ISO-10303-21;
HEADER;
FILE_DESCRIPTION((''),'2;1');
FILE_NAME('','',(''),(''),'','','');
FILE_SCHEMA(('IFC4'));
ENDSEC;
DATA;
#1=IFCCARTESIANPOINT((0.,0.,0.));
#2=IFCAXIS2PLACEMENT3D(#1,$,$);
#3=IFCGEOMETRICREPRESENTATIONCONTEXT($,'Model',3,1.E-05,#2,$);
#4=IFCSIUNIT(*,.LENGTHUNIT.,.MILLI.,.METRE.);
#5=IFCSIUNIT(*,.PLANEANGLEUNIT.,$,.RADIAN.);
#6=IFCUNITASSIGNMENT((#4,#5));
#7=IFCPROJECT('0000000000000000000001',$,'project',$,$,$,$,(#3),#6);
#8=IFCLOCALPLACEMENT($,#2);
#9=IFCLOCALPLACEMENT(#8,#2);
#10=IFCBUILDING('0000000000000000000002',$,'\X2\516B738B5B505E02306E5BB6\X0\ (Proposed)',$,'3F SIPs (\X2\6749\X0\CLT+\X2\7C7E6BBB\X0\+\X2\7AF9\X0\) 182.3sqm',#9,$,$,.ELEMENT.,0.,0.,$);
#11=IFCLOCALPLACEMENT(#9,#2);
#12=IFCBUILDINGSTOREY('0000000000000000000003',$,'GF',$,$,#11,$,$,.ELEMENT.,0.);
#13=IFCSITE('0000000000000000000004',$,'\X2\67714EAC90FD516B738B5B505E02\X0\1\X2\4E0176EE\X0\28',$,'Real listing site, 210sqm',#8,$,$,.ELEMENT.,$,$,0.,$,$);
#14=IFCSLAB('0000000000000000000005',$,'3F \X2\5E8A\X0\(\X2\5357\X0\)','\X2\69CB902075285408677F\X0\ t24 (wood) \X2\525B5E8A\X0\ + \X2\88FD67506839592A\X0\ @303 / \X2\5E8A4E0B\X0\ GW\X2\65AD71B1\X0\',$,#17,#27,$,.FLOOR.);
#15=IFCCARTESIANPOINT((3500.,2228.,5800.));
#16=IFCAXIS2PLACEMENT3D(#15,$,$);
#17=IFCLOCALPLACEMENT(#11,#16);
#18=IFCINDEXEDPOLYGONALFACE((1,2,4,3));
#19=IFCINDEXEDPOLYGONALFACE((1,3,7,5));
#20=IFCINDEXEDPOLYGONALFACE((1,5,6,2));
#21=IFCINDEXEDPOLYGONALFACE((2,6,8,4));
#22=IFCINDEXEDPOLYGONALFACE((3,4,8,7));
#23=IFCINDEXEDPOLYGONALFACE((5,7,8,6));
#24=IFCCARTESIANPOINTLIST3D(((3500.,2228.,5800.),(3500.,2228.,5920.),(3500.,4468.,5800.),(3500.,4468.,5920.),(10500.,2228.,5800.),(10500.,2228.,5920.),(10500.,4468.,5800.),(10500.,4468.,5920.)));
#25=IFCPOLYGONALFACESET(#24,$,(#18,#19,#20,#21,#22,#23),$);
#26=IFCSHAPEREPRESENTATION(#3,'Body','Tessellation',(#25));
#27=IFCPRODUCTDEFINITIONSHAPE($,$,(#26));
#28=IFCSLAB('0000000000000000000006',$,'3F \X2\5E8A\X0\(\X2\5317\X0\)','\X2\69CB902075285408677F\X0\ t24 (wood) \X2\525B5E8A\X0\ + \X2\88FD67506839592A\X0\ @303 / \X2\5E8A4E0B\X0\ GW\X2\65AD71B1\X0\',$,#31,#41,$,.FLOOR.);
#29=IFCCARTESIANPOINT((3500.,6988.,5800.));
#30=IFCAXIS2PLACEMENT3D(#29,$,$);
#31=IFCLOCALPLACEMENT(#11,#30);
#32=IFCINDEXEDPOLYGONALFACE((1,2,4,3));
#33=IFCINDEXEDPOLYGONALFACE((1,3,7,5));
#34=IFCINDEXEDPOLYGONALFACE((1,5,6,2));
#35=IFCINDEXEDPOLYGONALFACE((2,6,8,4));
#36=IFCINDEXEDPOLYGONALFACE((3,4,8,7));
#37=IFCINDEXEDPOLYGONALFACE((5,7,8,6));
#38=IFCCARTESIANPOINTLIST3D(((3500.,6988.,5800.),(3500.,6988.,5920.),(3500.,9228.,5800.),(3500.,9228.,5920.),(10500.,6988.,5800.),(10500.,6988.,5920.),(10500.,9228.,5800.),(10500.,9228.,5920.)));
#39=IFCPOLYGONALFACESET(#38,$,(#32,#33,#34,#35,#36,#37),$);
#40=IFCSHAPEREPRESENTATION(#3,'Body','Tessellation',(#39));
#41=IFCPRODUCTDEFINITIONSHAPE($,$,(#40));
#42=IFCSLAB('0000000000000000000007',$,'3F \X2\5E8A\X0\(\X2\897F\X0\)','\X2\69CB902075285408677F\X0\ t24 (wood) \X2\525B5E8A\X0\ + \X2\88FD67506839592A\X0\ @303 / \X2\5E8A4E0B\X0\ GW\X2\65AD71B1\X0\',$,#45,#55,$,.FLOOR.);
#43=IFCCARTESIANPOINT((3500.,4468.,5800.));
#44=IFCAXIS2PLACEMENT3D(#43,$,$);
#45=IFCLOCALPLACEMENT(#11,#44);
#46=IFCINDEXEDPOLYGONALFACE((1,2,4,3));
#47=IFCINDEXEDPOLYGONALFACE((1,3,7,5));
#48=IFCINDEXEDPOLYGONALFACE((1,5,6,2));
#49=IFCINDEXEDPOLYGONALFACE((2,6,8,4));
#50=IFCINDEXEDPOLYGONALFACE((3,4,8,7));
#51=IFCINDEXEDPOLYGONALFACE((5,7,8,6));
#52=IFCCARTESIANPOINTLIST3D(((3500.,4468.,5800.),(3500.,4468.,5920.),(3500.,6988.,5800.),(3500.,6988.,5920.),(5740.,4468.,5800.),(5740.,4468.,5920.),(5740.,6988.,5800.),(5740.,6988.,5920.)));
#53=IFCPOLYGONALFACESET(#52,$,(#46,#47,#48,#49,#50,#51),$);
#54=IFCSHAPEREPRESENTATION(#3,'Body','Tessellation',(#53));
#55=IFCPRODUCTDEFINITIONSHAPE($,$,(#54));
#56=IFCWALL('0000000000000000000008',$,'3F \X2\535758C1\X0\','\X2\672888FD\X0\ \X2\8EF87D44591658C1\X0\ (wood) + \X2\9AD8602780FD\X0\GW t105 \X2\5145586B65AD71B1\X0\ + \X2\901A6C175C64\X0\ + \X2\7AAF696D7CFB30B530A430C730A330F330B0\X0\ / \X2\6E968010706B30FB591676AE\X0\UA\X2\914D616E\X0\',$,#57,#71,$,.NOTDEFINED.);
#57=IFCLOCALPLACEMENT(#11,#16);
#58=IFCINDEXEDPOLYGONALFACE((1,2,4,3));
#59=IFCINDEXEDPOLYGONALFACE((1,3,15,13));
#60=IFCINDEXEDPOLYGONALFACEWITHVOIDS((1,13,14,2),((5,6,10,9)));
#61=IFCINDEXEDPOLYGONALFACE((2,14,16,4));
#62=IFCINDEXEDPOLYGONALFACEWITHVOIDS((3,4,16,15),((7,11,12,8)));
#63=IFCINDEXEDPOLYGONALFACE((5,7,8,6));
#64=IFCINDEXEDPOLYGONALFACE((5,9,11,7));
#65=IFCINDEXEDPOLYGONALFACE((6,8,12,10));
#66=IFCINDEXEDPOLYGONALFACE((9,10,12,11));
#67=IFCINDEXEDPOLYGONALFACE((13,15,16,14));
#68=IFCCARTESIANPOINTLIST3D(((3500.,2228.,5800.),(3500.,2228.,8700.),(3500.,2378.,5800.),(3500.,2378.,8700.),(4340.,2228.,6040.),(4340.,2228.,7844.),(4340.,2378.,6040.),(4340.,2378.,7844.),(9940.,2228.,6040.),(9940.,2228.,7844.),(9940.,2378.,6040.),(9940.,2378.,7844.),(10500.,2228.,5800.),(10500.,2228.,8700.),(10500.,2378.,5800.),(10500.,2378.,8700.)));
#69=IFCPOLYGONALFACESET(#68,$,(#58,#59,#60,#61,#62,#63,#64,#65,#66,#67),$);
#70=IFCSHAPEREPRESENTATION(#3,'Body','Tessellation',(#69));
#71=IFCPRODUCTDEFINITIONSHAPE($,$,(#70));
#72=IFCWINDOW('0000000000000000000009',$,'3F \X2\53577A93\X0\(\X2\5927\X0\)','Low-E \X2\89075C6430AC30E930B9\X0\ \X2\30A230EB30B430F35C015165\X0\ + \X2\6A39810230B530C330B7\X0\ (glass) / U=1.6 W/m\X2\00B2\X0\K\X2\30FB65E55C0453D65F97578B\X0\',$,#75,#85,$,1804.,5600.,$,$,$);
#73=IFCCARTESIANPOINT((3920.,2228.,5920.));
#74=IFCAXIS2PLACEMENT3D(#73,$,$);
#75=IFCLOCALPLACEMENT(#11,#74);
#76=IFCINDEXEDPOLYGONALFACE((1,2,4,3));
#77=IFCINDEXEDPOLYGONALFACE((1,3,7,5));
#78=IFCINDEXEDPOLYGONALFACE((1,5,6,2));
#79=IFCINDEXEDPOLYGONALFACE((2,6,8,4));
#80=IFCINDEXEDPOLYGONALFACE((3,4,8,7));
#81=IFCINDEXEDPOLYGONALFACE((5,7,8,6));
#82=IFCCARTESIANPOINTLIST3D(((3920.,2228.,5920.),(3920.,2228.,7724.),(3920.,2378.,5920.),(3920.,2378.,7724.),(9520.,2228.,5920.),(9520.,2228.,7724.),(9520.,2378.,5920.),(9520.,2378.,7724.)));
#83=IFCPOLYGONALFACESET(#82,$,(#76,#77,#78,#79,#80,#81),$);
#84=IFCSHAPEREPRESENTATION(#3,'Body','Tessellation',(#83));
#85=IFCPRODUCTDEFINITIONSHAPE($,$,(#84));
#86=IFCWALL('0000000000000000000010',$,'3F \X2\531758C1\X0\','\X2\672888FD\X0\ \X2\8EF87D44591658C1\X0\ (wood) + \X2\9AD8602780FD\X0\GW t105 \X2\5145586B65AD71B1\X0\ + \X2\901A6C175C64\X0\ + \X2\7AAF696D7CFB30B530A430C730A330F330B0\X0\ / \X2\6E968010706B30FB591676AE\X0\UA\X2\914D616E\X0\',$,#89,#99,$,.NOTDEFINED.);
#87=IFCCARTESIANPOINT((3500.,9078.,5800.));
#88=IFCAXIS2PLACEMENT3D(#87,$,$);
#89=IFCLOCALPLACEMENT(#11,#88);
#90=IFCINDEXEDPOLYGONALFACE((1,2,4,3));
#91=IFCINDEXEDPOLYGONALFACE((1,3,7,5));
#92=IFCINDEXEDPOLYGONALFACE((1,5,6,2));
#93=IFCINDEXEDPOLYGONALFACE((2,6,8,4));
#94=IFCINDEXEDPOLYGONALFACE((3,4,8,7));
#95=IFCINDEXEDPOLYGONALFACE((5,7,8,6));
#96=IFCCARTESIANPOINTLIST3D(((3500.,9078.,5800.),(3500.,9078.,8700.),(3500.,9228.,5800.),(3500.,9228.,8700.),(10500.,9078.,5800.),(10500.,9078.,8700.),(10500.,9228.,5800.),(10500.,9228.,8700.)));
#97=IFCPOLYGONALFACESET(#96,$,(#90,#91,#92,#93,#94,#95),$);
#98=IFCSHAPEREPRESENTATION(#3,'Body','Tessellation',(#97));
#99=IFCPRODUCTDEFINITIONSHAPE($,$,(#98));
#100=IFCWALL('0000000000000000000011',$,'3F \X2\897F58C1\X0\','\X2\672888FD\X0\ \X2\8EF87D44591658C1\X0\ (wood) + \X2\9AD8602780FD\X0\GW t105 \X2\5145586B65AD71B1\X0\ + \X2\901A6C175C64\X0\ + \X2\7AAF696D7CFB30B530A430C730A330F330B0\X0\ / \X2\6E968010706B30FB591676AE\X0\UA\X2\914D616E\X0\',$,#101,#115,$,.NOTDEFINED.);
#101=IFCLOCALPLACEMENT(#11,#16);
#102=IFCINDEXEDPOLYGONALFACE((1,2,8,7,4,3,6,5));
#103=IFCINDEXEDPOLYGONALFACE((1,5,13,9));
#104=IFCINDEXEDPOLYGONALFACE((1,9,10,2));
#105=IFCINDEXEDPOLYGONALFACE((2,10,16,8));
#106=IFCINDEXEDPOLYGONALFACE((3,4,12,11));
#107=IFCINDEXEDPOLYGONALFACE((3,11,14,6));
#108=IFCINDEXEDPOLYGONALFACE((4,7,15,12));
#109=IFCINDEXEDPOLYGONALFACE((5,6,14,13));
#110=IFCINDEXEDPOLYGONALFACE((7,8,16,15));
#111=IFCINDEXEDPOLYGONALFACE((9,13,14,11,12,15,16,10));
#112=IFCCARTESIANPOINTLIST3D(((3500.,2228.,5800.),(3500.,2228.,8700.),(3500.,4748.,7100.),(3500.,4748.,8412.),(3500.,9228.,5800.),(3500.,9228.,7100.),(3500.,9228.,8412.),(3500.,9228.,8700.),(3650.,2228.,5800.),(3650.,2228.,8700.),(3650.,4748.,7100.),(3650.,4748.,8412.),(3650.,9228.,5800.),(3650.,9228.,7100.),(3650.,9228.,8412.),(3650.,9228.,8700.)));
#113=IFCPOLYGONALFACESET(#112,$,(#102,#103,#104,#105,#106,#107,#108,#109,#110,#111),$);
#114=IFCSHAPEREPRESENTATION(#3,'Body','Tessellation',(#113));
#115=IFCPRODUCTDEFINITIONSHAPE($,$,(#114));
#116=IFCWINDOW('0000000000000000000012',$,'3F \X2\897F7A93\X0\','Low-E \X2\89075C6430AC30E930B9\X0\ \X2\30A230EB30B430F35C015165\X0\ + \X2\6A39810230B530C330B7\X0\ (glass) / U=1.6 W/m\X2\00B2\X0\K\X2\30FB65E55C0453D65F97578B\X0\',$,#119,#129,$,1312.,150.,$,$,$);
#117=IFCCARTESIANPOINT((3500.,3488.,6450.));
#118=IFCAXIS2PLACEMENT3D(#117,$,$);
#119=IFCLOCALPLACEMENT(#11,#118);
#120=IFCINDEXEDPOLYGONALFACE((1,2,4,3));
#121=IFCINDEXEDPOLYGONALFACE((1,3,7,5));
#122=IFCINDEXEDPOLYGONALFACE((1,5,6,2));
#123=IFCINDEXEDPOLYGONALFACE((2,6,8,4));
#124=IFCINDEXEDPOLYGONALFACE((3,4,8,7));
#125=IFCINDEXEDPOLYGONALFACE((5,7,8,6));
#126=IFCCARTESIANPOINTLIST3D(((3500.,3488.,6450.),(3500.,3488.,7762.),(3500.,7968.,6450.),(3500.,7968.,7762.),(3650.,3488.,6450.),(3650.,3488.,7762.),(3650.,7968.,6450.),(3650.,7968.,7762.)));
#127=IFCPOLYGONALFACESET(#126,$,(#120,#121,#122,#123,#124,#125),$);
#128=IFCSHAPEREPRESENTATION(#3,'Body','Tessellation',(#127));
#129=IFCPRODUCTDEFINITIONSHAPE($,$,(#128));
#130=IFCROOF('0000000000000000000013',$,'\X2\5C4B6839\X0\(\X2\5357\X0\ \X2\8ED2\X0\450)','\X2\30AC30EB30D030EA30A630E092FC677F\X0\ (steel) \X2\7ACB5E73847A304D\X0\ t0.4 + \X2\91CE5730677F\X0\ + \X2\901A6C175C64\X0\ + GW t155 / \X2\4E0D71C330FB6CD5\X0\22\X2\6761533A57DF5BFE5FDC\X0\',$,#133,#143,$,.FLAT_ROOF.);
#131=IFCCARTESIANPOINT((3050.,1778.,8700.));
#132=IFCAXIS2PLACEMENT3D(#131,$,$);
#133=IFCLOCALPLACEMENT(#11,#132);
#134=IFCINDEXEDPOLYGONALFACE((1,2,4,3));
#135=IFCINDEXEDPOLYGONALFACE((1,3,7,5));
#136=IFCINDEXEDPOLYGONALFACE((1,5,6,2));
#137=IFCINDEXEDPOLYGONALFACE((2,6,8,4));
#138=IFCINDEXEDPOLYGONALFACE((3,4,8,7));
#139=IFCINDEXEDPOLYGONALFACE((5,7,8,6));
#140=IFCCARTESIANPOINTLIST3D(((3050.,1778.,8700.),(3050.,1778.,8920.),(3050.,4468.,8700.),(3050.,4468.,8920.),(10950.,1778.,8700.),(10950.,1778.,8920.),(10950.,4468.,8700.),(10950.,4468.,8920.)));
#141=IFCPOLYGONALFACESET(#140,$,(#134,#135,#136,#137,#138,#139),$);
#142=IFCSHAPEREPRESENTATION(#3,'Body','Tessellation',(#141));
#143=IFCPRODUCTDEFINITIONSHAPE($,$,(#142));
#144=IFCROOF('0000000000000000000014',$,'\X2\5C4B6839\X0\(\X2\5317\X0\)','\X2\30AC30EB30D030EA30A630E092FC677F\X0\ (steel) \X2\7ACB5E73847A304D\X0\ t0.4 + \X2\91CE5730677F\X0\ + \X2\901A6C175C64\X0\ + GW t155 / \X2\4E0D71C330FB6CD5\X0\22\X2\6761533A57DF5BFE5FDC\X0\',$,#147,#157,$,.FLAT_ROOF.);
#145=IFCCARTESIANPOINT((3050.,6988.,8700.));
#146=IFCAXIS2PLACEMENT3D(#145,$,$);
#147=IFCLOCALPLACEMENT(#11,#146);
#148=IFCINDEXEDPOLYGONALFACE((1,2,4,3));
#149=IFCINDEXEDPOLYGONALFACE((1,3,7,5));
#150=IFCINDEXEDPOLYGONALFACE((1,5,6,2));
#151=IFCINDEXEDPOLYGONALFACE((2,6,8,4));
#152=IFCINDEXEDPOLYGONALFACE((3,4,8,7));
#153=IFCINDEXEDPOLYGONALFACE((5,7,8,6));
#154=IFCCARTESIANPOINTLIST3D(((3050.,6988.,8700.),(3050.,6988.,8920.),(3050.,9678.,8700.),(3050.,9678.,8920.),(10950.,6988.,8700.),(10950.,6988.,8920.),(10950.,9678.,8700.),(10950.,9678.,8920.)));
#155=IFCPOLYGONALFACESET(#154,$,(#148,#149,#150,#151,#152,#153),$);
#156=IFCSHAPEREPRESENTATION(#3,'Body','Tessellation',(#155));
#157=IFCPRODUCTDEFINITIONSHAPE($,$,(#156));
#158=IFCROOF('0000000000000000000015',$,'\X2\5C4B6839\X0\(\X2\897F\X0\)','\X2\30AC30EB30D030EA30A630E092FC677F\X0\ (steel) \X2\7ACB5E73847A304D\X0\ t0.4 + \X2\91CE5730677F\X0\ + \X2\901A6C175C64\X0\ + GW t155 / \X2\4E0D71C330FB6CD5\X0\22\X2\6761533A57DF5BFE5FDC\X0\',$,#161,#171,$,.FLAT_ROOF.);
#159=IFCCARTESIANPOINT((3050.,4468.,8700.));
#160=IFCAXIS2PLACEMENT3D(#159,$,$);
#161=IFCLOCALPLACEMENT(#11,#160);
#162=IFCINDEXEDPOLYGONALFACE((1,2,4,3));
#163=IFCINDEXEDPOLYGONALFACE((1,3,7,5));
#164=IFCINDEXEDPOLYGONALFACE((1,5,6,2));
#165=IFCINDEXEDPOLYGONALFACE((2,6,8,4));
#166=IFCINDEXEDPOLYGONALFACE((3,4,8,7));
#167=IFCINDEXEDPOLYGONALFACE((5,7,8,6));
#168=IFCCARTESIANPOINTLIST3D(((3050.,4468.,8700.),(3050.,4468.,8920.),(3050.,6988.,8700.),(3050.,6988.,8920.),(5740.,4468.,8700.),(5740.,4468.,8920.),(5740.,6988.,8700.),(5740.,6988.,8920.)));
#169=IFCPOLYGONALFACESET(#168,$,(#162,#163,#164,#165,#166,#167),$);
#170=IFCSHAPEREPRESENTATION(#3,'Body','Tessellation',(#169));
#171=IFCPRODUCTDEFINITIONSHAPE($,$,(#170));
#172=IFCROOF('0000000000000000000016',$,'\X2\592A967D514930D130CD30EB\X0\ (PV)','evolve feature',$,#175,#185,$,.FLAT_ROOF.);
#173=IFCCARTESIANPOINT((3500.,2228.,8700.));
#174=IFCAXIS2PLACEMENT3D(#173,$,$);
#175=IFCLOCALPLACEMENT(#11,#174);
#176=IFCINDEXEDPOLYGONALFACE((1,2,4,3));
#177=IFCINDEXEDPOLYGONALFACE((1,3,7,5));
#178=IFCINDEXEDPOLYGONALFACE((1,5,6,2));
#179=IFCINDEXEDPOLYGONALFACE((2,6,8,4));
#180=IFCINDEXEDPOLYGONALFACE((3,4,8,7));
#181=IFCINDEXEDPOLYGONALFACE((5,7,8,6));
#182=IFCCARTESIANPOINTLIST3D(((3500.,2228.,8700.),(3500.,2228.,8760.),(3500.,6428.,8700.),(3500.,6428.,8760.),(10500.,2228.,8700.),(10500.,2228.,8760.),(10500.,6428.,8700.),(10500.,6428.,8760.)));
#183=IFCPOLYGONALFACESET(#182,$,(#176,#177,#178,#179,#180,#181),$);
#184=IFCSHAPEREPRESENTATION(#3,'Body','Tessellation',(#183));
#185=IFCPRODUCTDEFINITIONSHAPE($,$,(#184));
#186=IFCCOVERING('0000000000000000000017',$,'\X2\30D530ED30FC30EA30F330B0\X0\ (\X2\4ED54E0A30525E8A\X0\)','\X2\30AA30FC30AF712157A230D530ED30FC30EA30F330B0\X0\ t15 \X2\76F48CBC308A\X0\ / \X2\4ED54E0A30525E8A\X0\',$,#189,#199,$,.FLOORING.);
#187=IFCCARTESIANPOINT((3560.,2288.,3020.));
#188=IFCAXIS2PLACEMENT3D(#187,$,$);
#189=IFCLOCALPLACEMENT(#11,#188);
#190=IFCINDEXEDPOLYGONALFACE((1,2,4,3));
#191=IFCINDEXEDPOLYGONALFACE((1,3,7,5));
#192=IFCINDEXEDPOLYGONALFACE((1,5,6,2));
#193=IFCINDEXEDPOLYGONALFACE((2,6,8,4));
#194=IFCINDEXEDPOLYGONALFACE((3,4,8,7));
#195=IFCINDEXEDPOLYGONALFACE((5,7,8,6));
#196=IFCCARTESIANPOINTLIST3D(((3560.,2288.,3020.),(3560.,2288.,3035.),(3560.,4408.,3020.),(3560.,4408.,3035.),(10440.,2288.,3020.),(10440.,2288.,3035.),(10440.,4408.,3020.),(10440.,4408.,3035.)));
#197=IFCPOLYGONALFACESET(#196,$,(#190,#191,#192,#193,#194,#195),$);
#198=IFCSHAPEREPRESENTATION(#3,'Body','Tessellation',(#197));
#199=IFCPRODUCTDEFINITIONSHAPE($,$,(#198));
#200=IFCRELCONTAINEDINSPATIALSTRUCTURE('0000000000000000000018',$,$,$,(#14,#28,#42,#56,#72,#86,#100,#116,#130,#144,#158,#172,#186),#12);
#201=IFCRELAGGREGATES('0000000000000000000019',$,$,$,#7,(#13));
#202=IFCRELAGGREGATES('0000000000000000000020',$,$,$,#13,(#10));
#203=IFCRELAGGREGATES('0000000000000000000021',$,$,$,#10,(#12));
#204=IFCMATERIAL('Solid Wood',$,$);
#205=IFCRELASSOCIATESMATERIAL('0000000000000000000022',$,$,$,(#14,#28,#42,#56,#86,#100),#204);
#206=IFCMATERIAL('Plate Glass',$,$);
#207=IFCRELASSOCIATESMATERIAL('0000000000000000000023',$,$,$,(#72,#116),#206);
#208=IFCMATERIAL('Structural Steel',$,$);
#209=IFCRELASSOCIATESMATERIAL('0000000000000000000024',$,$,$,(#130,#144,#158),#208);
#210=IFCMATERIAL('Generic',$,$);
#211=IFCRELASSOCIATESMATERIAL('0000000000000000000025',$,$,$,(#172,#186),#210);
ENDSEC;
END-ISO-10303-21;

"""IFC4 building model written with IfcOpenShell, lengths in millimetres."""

from ifc_helpers import new_model, si_unit, frame, frame_2d, origin, place, context, project, spatial, rectangle, extrude, material, element, fill, save


model = new_model("IFC4")

# Units and contexts
model_context = context("Model", 3, precision=1e-05, world=origin())
ifc_project = project(units=[si_unit("LENGTHUNIT", "METRE", prefix="MILLI"), si_unit("PLANEANGLEUNIT", "RADIAN")], contexts=[model_context])

# Site, building, storey
site_placement = place(None, origin())
site = spatial("IfcSite", under=ifc_project, at=site_placement, Name="東京都八王子市1丁目28", ObjectType="Real listing site, 210sqm", CompositionType="ELEMENT", RefElevation=0.0)
building_placement = place(site_placement, origin())
building = spatial("IfcBuilding", under=site, at=building_placement, Name="八王子市の家 (Proposed)", ObjectType="3F SIPs (杉CLT+籾殻+竹) 182.3sqm", CompositionType="ELEMENT", ElevationOfRefHeight=0.0, ElevationOfTerrain=0.0)
storey_placement = place(building_placement, origin())
storey = spatial("IfcBuildingStorey", under=building, at=storey_placement, Name="GF", CompositionType="ELEMENT", Elevation=0.0)

# Slabs
ifc_material_1 = material(Name="Solid Wood")
slab_1_placement = place(storey_placement, frame((3500.0, 2228.0, 5800.0)))
element("IfcSlab", 1, at=slab_1_placement, inside=storey, material=ifc_material_1, Name="3F 床(南)", Description="構造用合板 t24 (wood) 剛床 + 製材根太 @303 / 床下 GW断熱", PredefinedType="FLOOR", context=model_context, shape_type="SweptSolid", body=[
    extrude(rectangle(XDim=7000.0, YDim=2240.0, at=frame_2d((3500.0, 1120.0))), frame((3500.0, 2228.0, 5800.0)), (0.0, 0.0, 1.0), 120.0),
])
slab_2_placement = place(storey_placement, frame((3500.0, 6988.0, 5800.0)))
element("IfcSlab", 2, at=slab_2_placement, inside=storey, material=ifc_material_1, Name="3F 床(北)", Description="構造用合板 t24 (wood) 剛床 + 製材根太 @303 / 床下 GW断熱", PredefinedType="FLOOR", context=model_context, shape_type="SweptSolid", body=[
    extrude(rectangle(XDim=7000.0, YDim=2240.0, at=frame_2d((3500.0, 1120.0))), frame((3500.0, 6988.0, 5800.0)), (0.0, 0.0, 1.0), 120.0),
])
slab_3_placement = place(storey_placement, frame((3500.0, 4468.0, 5800.0)))
element("IfcSlab", 3, at=slab_3_placement, inside=storey, material=ifc_material_1, Name="3F 床(西)", Description="構造用合板 t24 (wood) 剛床 + 製材根太 @303 / 床下 GW断熱", PredefinedType="FLOOR", context=model_context, shape_type="SweptSolid", body=[
    extrude(rectangle(XDim=2240.0, YDim=2520.0, at=frame_2d((1120.0, 1260.0))), frame((3500.0, 4468.0, 5800.0)), (0.0, 0.0, 1.0), 120.0),
])

# Wall, opening, window
wall_1_placement = place(storey_placement, frame((3500.0, 2228.0, 5800.0)))
wall_1 = element("IfcWall", 4, at=wall_1_placement, inside=storey, material=ifc_material_1, Name="3F 南壁", Description="木製 軸組外壁 (wood) + 高性能GW t105 充填断熱 + 通気層 + 窯業系サイディング / 準耐火・外皮UA配慮", PredefinedType="NOTDEFINED", context=model_context, shape_type="SweptSolid", body=[
    extrude(rectangle(XDim=7000.0, YDim=150.0, at=frame_2d((3500.0, 75.0))), frame((3500.0, 2228.0, 5800.0)), (0.0, 0.0, 1.0), 2900.0),
])
opening_1_placement = place(storey_placement, frame((3920.0, 2228.0, 5920.0)))
opening_1 = element("IfcOpeningElement", 5, at=opening_1_placement, cuts=wall_1, PredefinedType="NOTDEFINED", context=model_context, shape_type="SweptSolid", body=[
    extrude(rectangle(XDim=5600.0, YDim=150.0, at=frame_2d((2800.0, 75.0))), frame((3920.0, 2228.0, 5920.0)), (0.0, 0.0, 1.0), 1804.0),
])
ifc_material_2 = material(Name="Plate Glass")
window_1_placement = place(storey_placement, frame((3920.0, 2228.0, 5920.0)))
window_1 = element("IfcWindow", 6, at=window_1_placement, inside=storey, material=ifc_material_2, Name="3F 南窓(大)", Description="Low-E 複層ガラス アルゴン封入 + 樹脂サッシ (glass) / U=1.6 W/m²K・日射取得型", OverallHeight=1804.0, OverallWidth=5600.0, context=model_context, shape_type="SweptSolid", body=[
    extrude(rectangle(XDim=5600.0, YDim=150.0, at=frame_2d((2800.0, 75.0))), frame((3920.0, 2228.0, 5920.0)), (0.0, 0.0, 1.0), 1804.0),
])
fill(opening_1, window_1)

# Wall
wall_2_placement = place(storey_placement, frame((3500.0, 9078.0, 5800.0)))
element("IfcWall", 7, at=wall_2_placement, inside=storey, material=ifc_material_1, Name="3F 北壁", Description="木製 軸組外壁 (wood) + 高性能GW t105 充填断熱 + 通気層 + 窯業系サイディング / 準耐火・外皮UA配慮", PredefinedType="NOTDEFINED", context=model_context, shape_type="SweptSolid", body=[
    extrude(rectangle(XDim=7000.0, YDim=150.0, at=frame_2d((3500.0, 75.0))), frame((3500.0, 9078.0, 5800.0)), (0.0, 0.0, 1.0), 2900.0),
])

# Wall, opening, window
wall_3_placement = place(storey_placement, frame((3500.0, 2228.0, 5800.0)))
wall_3 = element("IfcWall", 8, at=wall_3_placement, inside=storey, material=ifc_material_1, Name="3F 西壁", Description="木製 軸組外壁 (wood) + 高性能GW t105 充填断熱 + 通気層 + 窯業系サイディング / 準耐火・外皮UA配慮", PredefinedType="NOTDEFINED", context=model_context, shape_type="SweptSolid", body=[
    extrude(rectangle(XDim=150.0, YDim=7000.0, at=frame_2d((75.0, 3500.0))), frame((3500.0, 2228.0, 5800.0)), (0.0, 0.0, 1.0), 2900.0),
])
opening_2_placement = place(storey_placement, frame((3500.0, 3488.0, 6450.0)))
opening_2 = element("IfcOpeningElement", 9, at=opening_2_placement, cuts=wall_3, PredefinedType="NOTDEFINED", context=model_context, shape_type="SweptSolid", body=[
    extrude(rectangle(XDim=150.0, YDim=4480.0, at=frame_2d((75.0, 2240.0))), frame((3500.0, 3488.0, 6450.0)), (0.0, 0.0, 1.0), 1312.0),
])
window_2_placement = place(storey_placement, frame((3500.0, 3488.0, 6450.0)))
window_2 = element("IfcWindow", 10, at=window_2_placement, inside=storey, material=ifc_material_2, Name="3F 西窓", Description="Low-E 複層ガラス アルゴン封入 + 樹脂サッシ (glass) / U=1.6 W/m²K・日射取得型", OverallHeight=1312.0, OverallWidth=150.0, context=model_context, shape_type="SweptSolid", body=[
    extrude(rectangle(XDim=150.0, YDim=4480.0, at=frame_2d((75.0, 2240.0))), frame((3500.0, 3488.0, 6450.0)), (0.0, 0.0, 1.0), 1312.0),
])
fill(opening_2, window_2)

# Roofs
ifc_material_3 = material(Name="Structural Steel")
roof_1_placement = place(storey_placement, frame((3050.0, 1778.0, 8700.0)))
element("IfcRoof", 11, at=roof_1_placement, inside=storey, material=ifc_material_3, Name="屋根(南 軒450)", Description="ガルバリウム鋼板 (steel) 立平葺き t0.4 + 野地板 + 通気層 + GW t155 / 不燃・法22条区域対応", PredefinedType="FLAT_ROOF", context=model_context, shape_type="SweptSolid", body=[
    extrude(rectangle(XDim=7900.0, YDim=2690.0, at=frame_2d((3950.0, 1345.0))), frame((3050.0, 1778.0, 8700.0)), (0.0, 0.0, 1.0), 220.0),
])
roof_2_placement = place(storey_placement, frame((3050.0, 6988.0, 8700.0)))
element("IfcRoof", 12, at=roof_2_placement, inside=storey, material=ifc_material_3, Name="屋根(北)", Description="ガルバリウム鋼板 (steel) 立平葺き t0.4 + 野地板 + 通気層 + GW t155 / 不燃・法22条区域対応", PredefinedType="FLAT_ROOF", context=model_context, shape_type="SweptSolid", body=[
    extrude(rectangle(XDim=7900.0, YDim=2690.0, at=frame_2d((3950.0, 1345.0))), frame((3050.0, 6988.0, 8700.0)), (0.0, 0.0, 1.0), 220.0),
])
roof_3_placement = place(storey_placement, frame((3050.0, 4468.0, 8700.0)))
element("IfcRoof", 13, at=roof_3_placement, inside=storey, material=ifc_material_3, Name="屋根(西)", Description="ガルバリウム鋼板 (steel) 立平葺き t0.4 + 野地板 + 通気層 + GW t155 / 不燃・法22条区域対応", PredefinedType="FLAT_ROOF", context=model_context, shape_type="SweptSolid", body=[
    extrude(rectangle(XDim=2690.0, YDim=2520.0, at=frame_2d((1345.0, 1260.0))), frame((3050.0, 4468.0, 8700.0)), (0.0, 0.0, 1.0), 220.0),
])
ifc_material_4 = material(Name="Generic")
roof_4_placement = place(storey_placement, frame((3500.0, 2228.0, 8700.0)))
element("IfcRoof", 14, at=roof_4_placement, inside=storey, material=ifc_material_4, Name="太陽光パネル (PV)", Description="evolve feature", PredefinedType="FLAT_ROOF", context=model_context, shape_type="SweptSolid", body=[
    extrude(rectangle(XDim=7000.0, YDim=4200.0, at=frame_2d((3500.0, 2100.0))), frame((3500.0, 2228.0, 8700.0)), (0.0, 0.0, 1.0), 60.0),
])

# Covering
covering_1_placement = place(storey_placement, frame((3560.0, 2288.0, 3020.0)))
element("IfcCovering", 15, at=covering_1_placement, inside=storey, material=ifc_material_4, Name="フローリング (仕上げ床)", Description="オーク無垢フローリング t15 直貼り / 仕上げ床", PredefinedType="FLOORING", context=model_context, shape_type="SweptSolid", body=[
    extrude(rectangle(XDim=6880.0, YDim=2120.0, at=frame_2d((3440.0, 1060.0))), frame((3560.0, 2288.0, 3020.0)), (0.0, 0.0, 1.0), 15.0),
])

save(model, "model.ifc")
